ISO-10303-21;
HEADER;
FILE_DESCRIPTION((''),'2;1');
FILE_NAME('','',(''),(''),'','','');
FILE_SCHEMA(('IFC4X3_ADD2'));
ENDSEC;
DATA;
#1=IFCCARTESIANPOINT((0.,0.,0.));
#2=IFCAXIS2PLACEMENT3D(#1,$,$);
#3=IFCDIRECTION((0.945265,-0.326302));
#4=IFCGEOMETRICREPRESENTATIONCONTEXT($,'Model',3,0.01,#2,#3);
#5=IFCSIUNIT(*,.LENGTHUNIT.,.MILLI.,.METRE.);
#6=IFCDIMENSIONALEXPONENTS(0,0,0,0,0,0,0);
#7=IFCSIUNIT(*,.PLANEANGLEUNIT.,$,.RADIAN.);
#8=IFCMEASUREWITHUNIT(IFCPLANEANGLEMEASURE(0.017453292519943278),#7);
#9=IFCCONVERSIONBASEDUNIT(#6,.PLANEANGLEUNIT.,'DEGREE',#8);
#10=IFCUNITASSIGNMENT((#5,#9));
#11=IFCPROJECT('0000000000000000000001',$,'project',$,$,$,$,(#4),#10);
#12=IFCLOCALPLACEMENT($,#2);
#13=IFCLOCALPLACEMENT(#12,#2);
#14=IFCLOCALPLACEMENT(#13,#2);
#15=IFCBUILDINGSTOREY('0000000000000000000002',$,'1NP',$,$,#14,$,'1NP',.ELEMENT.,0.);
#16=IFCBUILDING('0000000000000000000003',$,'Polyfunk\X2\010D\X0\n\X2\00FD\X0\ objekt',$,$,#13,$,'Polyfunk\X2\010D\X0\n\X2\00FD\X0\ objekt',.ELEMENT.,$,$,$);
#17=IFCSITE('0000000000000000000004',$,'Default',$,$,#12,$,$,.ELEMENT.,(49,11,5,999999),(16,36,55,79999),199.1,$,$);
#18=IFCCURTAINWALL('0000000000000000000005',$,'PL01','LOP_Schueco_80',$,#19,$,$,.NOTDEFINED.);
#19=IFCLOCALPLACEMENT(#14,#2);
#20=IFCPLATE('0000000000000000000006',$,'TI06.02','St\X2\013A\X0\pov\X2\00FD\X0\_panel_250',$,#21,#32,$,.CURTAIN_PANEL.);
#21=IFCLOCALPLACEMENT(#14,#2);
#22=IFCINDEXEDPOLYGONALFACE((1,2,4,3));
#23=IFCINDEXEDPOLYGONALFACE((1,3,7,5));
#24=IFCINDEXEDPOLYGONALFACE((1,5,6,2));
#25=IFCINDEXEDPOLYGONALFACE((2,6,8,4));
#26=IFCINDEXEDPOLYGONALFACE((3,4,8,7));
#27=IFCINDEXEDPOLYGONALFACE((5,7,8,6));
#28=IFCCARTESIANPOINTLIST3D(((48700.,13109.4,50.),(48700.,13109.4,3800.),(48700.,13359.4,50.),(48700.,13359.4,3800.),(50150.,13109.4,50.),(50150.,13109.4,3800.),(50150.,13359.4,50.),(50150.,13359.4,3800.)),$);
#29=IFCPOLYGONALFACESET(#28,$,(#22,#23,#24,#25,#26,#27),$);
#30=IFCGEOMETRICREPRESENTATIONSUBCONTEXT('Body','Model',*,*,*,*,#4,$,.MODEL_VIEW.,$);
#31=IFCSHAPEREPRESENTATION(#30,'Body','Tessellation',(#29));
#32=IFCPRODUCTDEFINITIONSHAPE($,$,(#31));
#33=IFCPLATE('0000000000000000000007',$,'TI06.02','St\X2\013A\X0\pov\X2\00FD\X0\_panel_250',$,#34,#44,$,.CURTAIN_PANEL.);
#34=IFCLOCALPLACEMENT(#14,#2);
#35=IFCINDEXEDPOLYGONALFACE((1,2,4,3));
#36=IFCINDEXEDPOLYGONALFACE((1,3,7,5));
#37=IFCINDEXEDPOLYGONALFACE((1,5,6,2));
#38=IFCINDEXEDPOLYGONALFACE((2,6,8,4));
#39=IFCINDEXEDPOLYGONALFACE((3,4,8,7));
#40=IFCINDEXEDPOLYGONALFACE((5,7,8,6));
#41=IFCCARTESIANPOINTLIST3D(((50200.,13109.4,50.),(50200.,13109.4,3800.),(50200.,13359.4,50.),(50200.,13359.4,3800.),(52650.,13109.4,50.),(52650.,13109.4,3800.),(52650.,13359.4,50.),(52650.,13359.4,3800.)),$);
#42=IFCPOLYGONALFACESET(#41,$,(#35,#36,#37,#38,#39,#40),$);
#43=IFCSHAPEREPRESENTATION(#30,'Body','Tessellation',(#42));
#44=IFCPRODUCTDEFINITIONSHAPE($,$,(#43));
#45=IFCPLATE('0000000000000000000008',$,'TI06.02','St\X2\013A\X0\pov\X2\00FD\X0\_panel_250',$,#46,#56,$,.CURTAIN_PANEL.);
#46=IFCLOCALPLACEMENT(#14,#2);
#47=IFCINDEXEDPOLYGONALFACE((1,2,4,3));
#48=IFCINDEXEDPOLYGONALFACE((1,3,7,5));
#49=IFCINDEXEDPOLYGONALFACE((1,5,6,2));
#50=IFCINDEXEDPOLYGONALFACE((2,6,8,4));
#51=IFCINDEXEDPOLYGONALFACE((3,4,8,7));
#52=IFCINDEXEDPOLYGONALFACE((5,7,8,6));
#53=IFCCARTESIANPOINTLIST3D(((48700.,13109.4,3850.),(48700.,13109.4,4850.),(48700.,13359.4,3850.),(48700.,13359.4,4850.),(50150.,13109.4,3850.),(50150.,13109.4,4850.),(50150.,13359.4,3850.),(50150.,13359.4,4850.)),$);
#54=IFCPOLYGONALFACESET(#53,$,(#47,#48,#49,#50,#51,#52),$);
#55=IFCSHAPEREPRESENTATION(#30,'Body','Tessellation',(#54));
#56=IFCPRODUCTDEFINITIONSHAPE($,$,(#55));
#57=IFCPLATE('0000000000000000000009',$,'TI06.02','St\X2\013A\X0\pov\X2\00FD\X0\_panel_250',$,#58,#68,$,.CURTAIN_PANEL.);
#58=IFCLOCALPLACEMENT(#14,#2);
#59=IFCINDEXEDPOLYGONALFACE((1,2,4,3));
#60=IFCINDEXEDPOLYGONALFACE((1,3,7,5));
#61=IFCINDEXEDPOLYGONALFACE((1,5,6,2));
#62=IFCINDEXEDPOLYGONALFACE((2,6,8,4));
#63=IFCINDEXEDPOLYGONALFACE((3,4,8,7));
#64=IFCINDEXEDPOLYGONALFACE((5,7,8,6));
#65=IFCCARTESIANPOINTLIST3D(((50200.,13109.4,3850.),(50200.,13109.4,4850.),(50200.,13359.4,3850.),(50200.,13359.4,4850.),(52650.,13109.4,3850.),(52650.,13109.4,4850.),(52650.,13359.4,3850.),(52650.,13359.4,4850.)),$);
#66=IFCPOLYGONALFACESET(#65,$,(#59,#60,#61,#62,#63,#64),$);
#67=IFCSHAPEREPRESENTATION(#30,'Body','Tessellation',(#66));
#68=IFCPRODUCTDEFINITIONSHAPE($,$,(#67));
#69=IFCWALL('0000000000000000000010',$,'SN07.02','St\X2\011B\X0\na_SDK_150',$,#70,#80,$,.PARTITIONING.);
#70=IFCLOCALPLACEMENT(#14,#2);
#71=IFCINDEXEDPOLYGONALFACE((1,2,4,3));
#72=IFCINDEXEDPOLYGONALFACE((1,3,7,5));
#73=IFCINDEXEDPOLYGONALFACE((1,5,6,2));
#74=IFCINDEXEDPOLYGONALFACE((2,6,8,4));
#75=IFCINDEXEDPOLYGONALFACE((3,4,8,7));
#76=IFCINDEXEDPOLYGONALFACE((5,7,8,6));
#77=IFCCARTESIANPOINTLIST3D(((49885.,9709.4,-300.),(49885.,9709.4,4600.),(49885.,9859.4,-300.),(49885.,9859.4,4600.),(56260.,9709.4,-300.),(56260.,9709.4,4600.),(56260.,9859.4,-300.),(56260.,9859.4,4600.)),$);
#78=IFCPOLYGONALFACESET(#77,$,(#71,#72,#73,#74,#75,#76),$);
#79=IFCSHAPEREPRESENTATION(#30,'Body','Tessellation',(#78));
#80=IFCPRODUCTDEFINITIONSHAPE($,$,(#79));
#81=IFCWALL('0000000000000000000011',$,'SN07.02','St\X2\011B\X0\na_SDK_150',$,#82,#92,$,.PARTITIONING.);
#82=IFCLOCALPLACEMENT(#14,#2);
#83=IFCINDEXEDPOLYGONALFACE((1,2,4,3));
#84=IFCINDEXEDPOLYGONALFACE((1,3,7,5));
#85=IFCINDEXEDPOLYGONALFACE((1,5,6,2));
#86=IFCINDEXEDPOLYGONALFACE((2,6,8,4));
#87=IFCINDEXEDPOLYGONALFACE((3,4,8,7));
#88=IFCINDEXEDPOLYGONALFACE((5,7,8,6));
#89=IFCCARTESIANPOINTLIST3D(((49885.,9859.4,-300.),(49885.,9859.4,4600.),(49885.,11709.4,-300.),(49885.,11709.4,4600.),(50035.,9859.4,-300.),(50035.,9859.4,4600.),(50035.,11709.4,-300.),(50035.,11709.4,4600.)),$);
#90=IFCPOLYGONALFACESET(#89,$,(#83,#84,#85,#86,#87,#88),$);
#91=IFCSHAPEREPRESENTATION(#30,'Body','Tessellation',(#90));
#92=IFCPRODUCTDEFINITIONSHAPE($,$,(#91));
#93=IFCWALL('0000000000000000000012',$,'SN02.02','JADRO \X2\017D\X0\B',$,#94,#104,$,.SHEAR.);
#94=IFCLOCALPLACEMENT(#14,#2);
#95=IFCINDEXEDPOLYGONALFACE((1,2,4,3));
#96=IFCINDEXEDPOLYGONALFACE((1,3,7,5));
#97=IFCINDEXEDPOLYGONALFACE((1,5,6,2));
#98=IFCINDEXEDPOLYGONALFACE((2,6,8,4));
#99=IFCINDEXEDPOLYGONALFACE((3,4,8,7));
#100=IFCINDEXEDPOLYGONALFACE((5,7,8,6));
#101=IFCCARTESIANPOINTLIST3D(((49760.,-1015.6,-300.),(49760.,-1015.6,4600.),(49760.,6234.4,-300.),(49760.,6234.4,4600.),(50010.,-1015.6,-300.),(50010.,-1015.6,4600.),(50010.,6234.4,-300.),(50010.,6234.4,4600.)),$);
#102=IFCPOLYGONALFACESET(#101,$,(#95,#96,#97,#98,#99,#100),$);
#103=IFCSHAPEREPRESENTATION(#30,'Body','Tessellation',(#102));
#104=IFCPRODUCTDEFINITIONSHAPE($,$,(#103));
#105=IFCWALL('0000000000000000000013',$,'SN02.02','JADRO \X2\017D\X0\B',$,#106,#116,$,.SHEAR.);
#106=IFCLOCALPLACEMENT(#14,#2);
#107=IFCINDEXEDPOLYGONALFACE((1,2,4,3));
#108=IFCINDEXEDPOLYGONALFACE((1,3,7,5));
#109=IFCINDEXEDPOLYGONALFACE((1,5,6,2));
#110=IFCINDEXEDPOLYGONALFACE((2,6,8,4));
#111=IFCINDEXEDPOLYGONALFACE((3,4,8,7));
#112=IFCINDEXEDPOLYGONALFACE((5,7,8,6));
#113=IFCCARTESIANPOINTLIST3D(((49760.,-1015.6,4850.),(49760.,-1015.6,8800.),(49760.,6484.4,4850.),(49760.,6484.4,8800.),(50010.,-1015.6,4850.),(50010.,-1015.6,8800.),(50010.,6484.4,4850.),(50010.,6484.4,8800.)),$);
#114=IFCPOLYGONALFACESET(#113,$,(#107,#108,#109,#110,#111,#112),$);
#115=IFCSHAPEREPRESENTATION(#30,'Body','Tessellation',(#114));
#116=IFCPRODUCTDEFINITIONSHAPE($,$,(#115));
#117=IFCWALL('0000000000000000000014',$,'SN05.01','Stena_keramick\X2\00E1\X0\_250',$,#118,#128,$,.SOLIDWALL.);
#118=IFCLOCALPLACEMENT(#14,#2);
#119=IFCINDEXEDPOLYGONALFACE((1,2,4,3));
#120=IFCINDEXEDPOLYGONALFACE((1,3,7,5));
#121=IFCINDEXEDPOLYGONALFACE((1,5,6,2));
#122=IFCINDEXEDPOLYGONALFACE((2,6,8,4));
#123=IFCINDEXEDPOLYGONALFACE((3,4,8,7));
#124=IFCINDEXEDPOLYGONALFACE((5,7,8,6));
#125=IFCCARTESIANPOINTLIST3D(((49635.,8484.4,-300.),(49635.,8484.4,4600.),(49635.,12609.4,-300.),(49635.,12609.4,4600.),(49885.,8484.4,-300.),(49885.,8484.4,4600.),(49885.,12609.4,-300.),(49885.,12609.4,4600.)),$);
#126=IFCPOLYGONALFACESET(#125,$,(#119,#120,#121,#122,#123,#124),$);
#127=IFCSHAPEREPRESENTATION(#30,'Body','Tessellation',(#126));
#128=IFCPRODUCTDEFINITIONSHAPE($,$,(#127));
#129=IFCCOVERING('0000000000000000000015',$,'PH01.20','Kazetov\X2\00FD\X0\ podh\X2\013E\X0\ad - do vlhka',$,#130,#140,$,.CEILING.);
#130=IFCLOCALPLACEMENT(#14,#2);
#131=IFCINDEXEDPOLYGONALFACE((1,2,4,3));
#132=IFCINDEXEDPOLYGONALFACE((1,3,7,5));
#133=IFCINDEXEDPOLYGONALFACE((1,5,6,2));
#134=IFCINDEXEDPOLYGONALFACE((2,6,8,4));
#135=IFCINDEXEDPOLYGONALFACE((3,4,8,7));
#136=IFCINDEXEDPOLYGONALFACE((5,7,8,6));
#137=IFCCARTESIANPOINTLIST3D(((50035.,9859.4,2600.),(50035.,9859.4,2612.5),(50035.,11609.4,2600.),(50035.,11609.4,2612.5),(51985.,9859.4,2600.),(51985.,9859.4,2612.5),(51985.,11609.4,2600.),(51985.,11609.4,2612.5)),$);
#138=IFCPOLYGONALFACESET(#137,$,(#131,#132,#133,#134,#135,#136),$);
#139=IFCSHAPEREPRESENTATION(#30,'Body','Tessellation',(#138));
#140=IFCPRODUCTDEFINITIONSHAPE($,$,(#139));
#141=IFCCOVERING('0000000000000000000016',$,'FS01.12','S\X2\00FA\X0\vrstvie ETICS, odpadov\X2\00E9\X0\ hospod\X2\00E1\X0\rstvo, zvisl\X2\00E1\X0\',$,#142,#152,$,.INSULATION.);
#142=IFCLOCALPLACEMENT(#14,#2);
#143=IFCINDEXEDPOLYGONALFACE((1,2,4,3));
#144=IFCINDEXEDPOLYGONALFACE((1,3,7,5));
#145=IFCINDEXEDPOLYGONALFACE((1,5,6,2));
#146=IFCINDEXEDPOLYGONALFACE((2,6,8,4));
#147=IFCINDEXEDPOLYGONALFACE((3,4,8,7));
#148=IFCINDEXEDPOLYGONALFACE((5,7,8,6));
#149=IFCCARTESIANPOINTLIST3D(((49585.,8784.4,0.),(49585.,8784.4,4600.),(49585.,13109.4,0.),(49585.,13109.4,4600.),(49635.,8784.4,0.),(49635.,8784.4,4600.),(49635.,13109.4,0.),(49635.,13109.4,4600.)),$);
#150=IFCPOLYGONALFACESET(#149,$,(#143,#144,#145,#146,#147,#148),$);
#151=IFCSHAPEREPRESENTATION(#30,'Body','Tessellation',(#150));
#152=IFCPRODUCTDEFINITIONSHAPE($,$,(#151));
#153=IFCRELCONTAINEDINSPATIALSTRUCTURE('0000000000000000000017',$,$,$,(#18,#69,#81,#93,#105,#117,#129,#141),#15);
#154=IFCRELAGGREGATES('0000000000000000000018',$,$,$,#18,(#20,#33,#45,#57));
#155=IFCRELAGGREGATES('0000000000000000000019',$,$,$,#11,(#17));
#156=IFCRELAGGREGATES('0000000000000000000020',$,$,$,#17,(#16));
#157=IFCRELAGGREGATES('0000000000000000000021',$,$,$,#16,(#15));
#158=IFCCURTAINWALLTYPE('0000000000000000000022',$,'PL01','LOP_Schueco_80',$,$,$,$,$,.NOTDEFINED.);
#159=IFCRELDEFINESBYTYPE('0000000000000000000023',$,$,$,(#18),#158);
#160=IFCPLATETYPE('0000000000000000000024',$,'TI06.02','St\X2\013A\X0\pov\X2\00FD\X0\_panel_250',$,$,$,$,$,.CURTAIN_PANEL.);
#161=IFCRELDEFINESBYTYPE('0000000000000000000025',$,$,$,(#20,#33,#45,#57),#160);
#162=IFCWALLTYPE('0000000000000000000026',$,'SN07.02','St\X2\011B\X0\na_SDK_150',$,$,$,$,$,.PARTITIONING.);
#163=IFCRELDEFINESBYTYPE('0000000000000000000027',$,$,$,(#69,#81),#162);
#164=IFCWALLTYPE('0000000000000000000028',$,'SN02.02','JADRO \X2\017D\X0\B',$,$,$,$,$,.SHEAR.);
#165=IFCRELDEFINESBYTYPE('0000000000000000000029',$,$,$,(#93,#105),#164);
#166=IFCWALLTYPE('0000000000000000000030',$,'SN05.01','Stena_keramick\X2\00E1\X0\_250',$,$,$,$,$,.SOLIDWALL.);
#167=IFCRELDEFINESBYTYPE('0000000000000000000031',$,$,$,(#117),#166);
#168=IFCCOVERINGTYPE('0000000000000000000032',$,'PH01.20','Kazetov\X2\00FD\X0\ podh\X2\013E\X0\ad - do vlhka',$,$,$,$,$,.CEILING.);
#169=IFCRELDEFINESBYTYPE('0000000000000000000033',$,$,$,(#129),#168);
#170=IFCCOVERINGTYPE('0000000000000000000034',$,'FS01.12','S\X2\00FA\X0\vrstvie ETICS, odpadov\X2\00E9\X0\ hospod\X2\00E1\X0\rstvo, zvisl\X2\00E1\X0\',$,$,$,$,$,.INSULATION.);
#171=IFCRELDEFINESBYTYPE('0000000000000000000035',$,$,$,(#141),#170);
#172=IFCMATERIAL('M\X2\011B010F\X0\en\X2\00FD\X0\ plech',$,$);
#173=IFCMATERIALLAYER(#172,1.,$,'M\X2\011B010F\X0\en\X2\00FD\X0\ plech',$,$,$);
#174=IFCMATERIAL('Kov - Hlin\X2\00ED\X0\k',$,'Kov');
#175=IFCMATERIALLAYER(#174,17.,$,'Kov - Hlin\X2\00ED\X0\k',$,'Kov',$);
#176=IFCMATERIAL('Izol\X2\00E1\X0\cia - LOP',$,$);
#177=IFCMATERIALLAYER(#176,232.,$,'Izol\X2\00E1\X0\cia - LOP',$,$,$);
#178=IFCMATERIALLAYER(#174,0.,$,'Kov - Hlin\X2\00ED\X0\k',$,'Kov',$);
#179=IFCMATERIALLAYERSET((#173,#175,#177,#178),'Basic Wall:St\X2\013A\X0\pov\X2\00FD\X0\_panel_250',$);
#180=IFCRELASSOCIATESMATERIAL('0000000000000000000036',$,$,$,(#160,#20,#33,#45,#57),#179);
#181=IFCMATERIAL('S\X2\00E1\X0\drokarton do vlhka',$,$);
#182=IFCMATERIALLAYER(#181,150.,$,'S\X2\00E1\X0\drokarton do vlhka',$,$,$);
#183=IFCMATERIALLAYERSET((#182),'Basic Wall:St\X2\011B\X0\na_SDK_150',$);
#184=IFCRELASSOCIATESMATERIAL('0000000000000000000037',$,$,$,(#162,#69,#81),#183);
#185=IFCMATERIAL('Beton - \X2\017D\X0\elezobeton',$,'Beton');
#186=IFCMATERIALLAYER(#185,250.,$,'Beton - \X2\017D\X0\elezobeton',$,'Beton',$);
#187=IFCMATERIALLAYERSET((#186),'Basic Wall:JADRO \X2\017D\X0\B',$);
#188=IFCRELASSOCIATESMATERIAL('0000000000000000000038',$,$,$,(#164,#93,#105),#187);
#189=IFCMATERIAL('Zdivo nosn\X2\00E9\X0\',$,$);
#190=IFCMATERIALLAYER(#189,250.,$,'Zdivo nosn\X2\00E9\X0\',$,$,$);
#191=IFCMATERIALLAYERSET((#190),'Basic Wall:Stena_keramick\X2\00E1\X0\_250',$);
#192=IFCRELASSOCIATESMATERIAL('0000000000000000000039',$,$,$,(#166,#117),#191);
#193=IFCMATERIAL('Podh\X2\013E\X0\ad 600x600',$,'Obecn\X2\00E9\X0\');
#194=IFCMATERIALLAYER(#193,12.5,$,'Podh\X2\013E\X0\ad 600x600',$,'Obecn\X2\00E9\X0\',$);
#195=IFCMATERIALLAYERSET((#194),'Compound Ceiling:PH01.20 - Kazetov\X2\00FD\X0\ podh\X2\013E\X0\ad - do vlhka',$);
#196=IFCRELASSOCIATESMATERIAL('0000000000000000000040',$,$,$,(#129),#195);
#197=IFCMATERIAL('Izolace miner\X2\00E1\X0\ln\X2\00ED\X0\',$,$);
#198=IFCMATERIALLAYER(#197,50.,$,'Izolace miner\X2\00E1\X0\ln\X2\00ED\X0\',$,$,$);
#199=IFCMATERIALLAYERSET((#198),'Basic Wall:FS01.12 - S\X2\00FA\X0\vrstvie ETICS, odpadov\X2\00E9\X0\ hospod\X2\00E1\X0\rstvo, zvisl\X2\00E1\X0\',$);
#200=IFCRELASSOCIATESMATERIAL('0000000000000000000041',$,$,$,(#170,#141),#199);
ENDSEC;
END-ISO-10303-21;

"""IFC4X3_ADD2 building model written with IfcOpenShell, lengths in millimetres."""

from ifc_helpers import new_model, entity, si_unit, converted_unit, direction, frame, frame_2d, origin, origin_2d_with_axis, place, context, subcontext, project, spatial, polyline, rectangle, extrude, clip, bounded_halfspace, material, layer, layer_set, layer_usage, type_object, element, aggregate, save


model = new_model("IFC4X3_ADD2")

# Units and contexts
model_context = context("Model", 3, precision=0.01, world=origin(), true_north=direction((0.945265, -0.326302)))
body_context = subcontext(model_context, "Body", "Model", "MODEL_VIEW")
ifc_project = project(units=[si_unit("LENGTHUNIT", "METRE", prefix="MILLI"), converted_unit("PLANEANGLEUNIT", "DEGREE", entity("IfcPlaneAngleMeasure", 0.017453292519943278), si_unit("PLANEANGLEUNIT", "RADIAN"), dimensions=[0, 0, 0, 0, 0, 0, 0])], contexts=[model_context])

# Site, building, storey
site_placement = place(None, origin())
site = spatial("IfcSite", under=ifc_project, at=site_placement, Name="Default", CompositionType="ELEMENT", RefLatitude=(49, 11, 5, 999999), RefLongitude=(16, 36, 55, 79999), RefElevation=199.1)
building_placement = place(site_placement, origin())
building = spatial("IfcBuilding", under=site, at=building_placement, Name="Polyfunkčný objekt", LongName="Polyfunkčný objekt", CompositionType="ELEMENT")
storey_placement = place(building_placement, origin())
storey = spatial("IfcBuildingStorey", under=building, at=storey_placement, Name="1NP", LongName="1NP", CompositionType="ELEMENT", Elevation=0.0)

# Curtain wall, plates
curtain_wall_type = type_object("IfcCurtainWallType", Name="PL01", Description="LOP_Schueco_80", PredefinedType="NOTDEFINED")
curtain_wall_placement = place(storey_placement, origin())
curtain_wall = element("IfcCurtainWall", 1, at=curtain_wall_placement, inside=storey, type_object=curtain_wall_type, Name="PL01", Description="LOP_Schueco_80", PredefinedType="NOTDEFINED")
ifc_material_1 = material(Name="Měďený plech")
ifc_layer_1 = layer(ifc_material_1, 1.0, Name="Měďený plech")
ifc_material_2 = material(Name="Kov - Hliník", Category="Kov")
ifc_layer_2 = layer(ifc_material_2, 17.0, Name="Kov - Hliník", Category="Kov")
ifc_material_3 = material(Name="Izolácia - LOP")
ifc_layer_3 = layer(ifc_material_3, 232.0, Name="Izolácia - LOP")
ifc_layer_4 = layer(ifc_material_2, 0.0, Name="Kov - Hliník", Category="Kov")
ifc_layer_set_1 = layer_set([ifc_layer_1, ifc_layer_2, ifc_layer_3, ifc_layer_4], Name="Basic Wall:Stĺpový_panel_250")
ifc_layer_usage_1 = layer_usage(ifc_layer_set_1, "AXIS2", "NEGATIVE", 125.0)
plate_type = type_object("IfcPlateType", Name="TI06.02", Description="Stĺpový_panel_250", PredefinedType="CURTAIN_PANEL", material=ifc_layer_set_1)
plate_1_placement = place(storey_placement, frame((48700.0, 13234.4, 50.0)))
plate_1 = element("IfcPlate", 2, at=plate_1_placement, type_object=plate_type, material=ifc_layer_usage_1, Name="TI06.02", Description="Stĺpový_panel_250", PredefinedType="CURTAIN_PANEL", context=body_context, shape_type="SweptSolid", body=[
    extrude(rectangle(XDim=250.0, YDim=1450.0, at=frame_2d((0.0, 0.0), x_axis=(1.0, 0.0))), frame((725.0, 0.0, 0.0), z_axis=(0.0, 0.0, 1.0), x_axis=(0.0, 1.0, 0.0)), (0.0, 0.0, 1.0), 3750.0),
])
ifc_layer_usage_2 = layer_usage(ifc_layer_set_1, "AXIS2", "NEGATIVE", 125.0)
plate_2_placement = place(storey_placement, frame((50200.0, 13234.4, 50.0)))
plate_2 = element("IfcPlate", 3, at=plate_2_placement, type_object=plate_type, material=ifc_layer_usage_2, Name="TI06.02", Description="Stĺpový_panel_250", PredefinedType="CURTAIN_PANEL", context=body_context, shape_type="SweptSolid", body=[
    extrude(rectangle(XDim=250.0, YDim=2450.0, at=origin_2d_with_axis()), frame((1225.0, 0.0, 0.0), z_axis=(0.0, 0.0, 1.0), x_axis=(0.0, 1.0, 0.0)), (0.0, 0.0, 1.0), 3750.0),
])
ifc_layer_usage_3 = layer_usage(ifc_layer_set_1, "AXIS2", "NEGATIVE", 125.0)
plate_3_placement = place(storey_placement, frame((48700.0, 13234.4, 3850.0)))
plate_3 = element("IfcPlate", 4, at=plate_3_placement, type_object=plate_type, material=ifc_layer_usage_3, Name="TI06.02", Description="Stĺpový_panel_250", PredefinedType="CURTAIN_PANEL", context=body_context, shape_type="SweptSolid", body=[
    extrude(rectangle(XDim=250.0, YDim=1450.0, at=frame_2d((0.0, 0.0), x_axis=(1.0, 0.0))), frame((725.0, 0.0, 0.0), z_axis=(0.0, 0.0, 1.0), x_axis=(0.0, 1.0, 0.0)), (0.0, 0.0, 1.0), 1000.0),
])
ifc_layer_usage_4 = layer_usage(ifc_layer_set_1, "AXIS2", "NEGATIVE", 125.0)
plate_4_placement = place(storey_placement, frame((50200.0, 13234.4, 3850.0)))
plate_4 = element("IfcPlate", 5, at=plate_4_placement, type_object=plate_type, material=ifc_layer_usage_4, Name="TI06.02", Description="Stĺpový_panel_250", PredefinedType="CURTAIN_PANEL", context=body_context, shape_type="SweptSolid", body=[
    extrude(rectangle(XDim=250.0, YDim=2450.0, at=origin_2d_with_axis()), frame((1225.0, 0.0, 0.0), z_axis=(0.0, 0.0, 1.0), x_axis=(0.0, 1.0, 0.0)), (0.0, 0.0, 1.0), 1000.0),
])
aggregate(curtain_wall, [plate_1, plate_2, plate_3, plate_4])

# Walls
ifc_material_4 = material(Name="Sádrokarton do vlhka")
ifc_layer_5 = layer(ifc_material_4, 150.0, Name="Sádrokarton do vlhka")
ifc_layer_set_2 = layer_set([ifc_layer_5], Name="Basic Wall:Stěna_SDK_150")
wall_type_1 = type_object("IfcWallType", Name="SN07.02", Description="Stěna_SDK_150", PredefinedType="PARTITIONING", material=ifc_layer_set_2)
wall_1_placement = place(storey_placement, frame((49885.0, 9784.4, -300.0)))
element("IfcWall", 6, at=wall_1_placement, inside=storey, type_object=wall_type_1, material=ifc_layer_set_2, Name="SN07.02", Description="Stěna_SDK_150", PredefinedType="PARTITIONING", context=body_context, shape_type="Clipping", body=[
    clip(clip(extrude(rectangle(XDim=6375.0, YDim=150.0, at=frame_2d((3187.5, 0.0), x_axis=(-1.0, 0.0))), origin(), (0.0, 0.0, 1.0), 4900.0), bounded_halfspace(frame((0.0, -75.0, 4900.0), z_axis=(0.0, 0.0, -1.0), x_axis=(1.0, 0.0, 0.0)), True, frame((0.0, -75.0, 4900.0)), polyline([(0.0, 0.0), (6375.0, 0.0), (6375.0, 150.0), (2250.0, 150.0), (2100.0, 150.0), (1200.0, 150.0), (1050.0, 150.0), (150.0, 150.0), (0.0, 150.0), (0.0, 0.0)]))), bounded_halfspace(frame((6375.0, -75.0, 0.0), z_axis=(0.0, 0.0, 1.0), x_axis=(0.0, 1.0, 0.0)), True, frame((6375.0, -75.0, 0.0)), polyline([(0.0, 0.0), (0.0, 150.0), (-4125.0, 150.0), (-4275.0, 150.0), (-5175.0, 150.0), (-5325.0, 150.0), (-6225.0, 150.0), (-6375.0, 150.0), (-6375.0, 0.0), (0.0, 0.0)]))),
])
wall_2_placement = place(storey_placement, frame((49960.0, 9859.4, -300.0), z_axis=(0.0, 0.0, 1.0), x_axis=(0.0, 1.0, 0.0)))
element("IfcWall", 7, at=wall_2_placement, inside=storey, type_object=wall_type_1, material=ifc_layer_set_2, Name="SN07.02", Description="Stěna_SDK_150", PredefinedType="PARTITIONING", context=body_context, shape_type="Clipping", body=[
    clip(clip(extrude(rectangle(XDim=1850.0, YDim=150.0, at=frame_2d((925.0, 0.0), x_axis=(-1.0, 0.0))), origin(), (0.0, 0.0, 1.0), 4900.0), bounded_halfspace(frame((0.0, -75.0, 4900.0), z_axis=(0.0, 0.0, -1.0), x_axis=(0.0, -1.0, 0.0)), True, frame((0.0, -75.0, 4900.0)), polyline([(0.0, 0.0), (1750.0, 0.0), (1850.0, 0.0), (1850.0, 150.0), (0.0, 150.0), (0.0, 0.0)]))), bounded_halfspace(frame((1850.0, -75.0, 0.0)), True, frame((1850.0, -75.0, 0.0)), polyline([(0.0, 0.0), (0.0, 150.0), (-1850.0, 150.0), (-1850.0, 0.0), (-100.0, 0.0), (0.0, 0.0)]))),
])
ifc_material_5 = material(Name="Beton - Železobeton", Category="Beton")
ifc_layer_6 = layer(ifc_material_5, 250.0, Name="Beton - Železobeton", Category="Beton")
ifc_layer_set_3 = layer_set([ifc_layer_6], Name="Basic Wall:JADRO ŽB")
wall_type_2 = type_object("IfcWallType", Name="SN02.02", Description="JADRO ŽB", PredefinedType="SHEAR", material=ifc_layer_set_3)
wall_3_placement = place(storey_placement, frame((49885.0, 6234.4, -300.0), z_axis=(0.0, 0.0, 1.0), x_axis=(0.0, -1.0, 0.0)))
element("IfcWall", 8, at=wall_3_placement, inside=storey, type_object=wall_type_2, material=ifc_layer_set_3, Name="SN02.02", Description="JADRO ŽB", PredefinedType="SHEAR", context=body_context, shape_type="Clipping", body=[
    clip(clip(extrude(rectangle(XDim=7250.0, YDim=250.0, at=frame_2d((3625.0, 0.0), x_axis=(-1.0, 0.0))), origin(), (0.0, 0.0, 1.0), 4900.0), bounded_halfspace(frame((0.0, -125.0, 4900.0), z_axis=(0.0, 0.0, -1.0), x_axis=(0.0, 1.0, 0.0)), True, frame((0.0, -125.0, 4900.0)), polyline([(0.0, 0.0), (800.0, 0.0), (950.0, 0.0), (7250.0, 0.0), (7250.0, 250.0), (0.0, 250.0), (0.0, 0.0)]))), bounded_halfspace(frame((7250.0, -125.0, 0.0), z_axis=(0.0, 0.0, 1.0), x_axis=(-1.0, 0.0, 0.0)), True, frame((7250.0, -125.0, 0.0)), polyline([(0.0, 0.0), (0.0, 250.0), (-7250.0, 250.0), (-7250.0, 0.0), (-6450.0, 0.0), (-6300.0, 0.0), (0.0, 0.0)]))),
])
wall_4_placement = place(storey_placement, frame((49885.0, 6484.4, 4850.0), z_axis=(0.0, 0.0, 1.0), x_axis=(0.0, -1.0, 0.0)))
element("IfcWall", 9, at=wall_4_placement, inside=storey, type_object=wall_type_2, material=ifc_layer_set_3, Name="SN02.02", Description="JADRO ŽB", PredefinedType="SHEAR", context=body_context, shape_type="Clipping", body=[
    clip(clip(extrude(rectangle(XDim=7500.0, YDim=250.0, at=frame_2d((3750.0, 0.0), x_axis=(-1.0, 0.0))), origin(), (0.0, 0.0, 1.0), 3950.0), bounded_halfspace(frame((7500.0, -125.0, 0.0), z_axis=(0.0, 0.0, 1.0), x_axis=(0.0, -1.0, 0.0)), True, frame((7500.0, -125.0, 0.0)), polyline([(0.0, 0.0), (0.0, 250.0), (-7500.0, 250.0), (-7500.0, 0.0), (-7250.0, 0.0), (-6450.0, 0.0), (-6300.0, 0.0), (0.0, 0.0)]))), bounded_halfspace(frame((0.0, -125.0, 3950.0), z_axis=(0.0, 0.0, -1.0), x_axis=(0.0, 1.0, 0.0)), True, frame((0.0, -125.0, 3950.0)), polyline([(0.0, 0.0), (250.0, 0.0), (1050.0, 0.0), (1200.0, 0.0), (7500.0, 0.0), (7500.0, 250.0), (0.0, 250.0), (0.0, 0.0)]))),
])
ifc_material_6 = material(Name="Zdivo nosné")
ifc_layer_7 = layer(ifc_material_6, 250.0, Name="Zdivo nosné")
ifc_layer_set_4 = layer_set([ifc_layer_7], Name="Basic Wall:Stena_keramická_250")
wall_type_3 = type_object("IfcWallType", Name="SN05.01", Description="Stena_keramická_250", PredefinedType="SOLIDWALL", material=ifc_layer_set_4)
wall_5_placement = place(storey_placement, frame((49760.0, 12609.4, -300.0), z_axis=(0.0, 0.0, 1.0), x_axis=(0.0, -1.0, 0.0)))
element("IfcWall", 10, at=wall_5_placement, inside=storey, type_object=wall_type_3, material=ifc_layer_set_4, Name="SN05.01", Description="Stena_keramická_250", PredefinedType="SOLIDWALL", context=body_context, shape_type="Clipping", body=[
    clip(clip(extrude(rectangle(XDim=4125.0, YDim=250.0, at=frame_2d((2062.5, 0.0), x_axis=(-1.0, 0.0))), origin(), (0.0, 0.0, 1.0), 4900.0), bounded_halfspace(frame((0.0, -125.0, 4900.0), z_axis=(0.0, 0.0, -1.0), x_axis=(0.0, 1.0, 0.0)), True, frame((0.0, -125.0, 4900.0)), polyline([(0.0, 0.0), (3875.0, 0.0), (4125.0, 0.0), (4125.0, 250.0), (0.0, 250.0), (0.0, 0.0)]))), bounded_halfspace(frame((4125.0, -125.0, 0.0), z_axis=(0.0, 0.0, 1.0), x_axis=(-1.0, 0.0, 0.0)), True, frame((4125.0, -125.0, 0.0)), polyline([(0.0, 0.0), (0.0, 250.0), (-4125.0, 250.0), (-4125.0, 0.0), (-250.0, 0.0), (0.0, 0.0)]))),
])

# Coverings
ifc_material_7 = material(Name="Podhľad 600x600", Category="Obecné")
ifc_layer_8 = layer(ifc_material_7, 12.5, Name="Podhľad 600x600", Category="Obecné")
ifc_layer_set_5 = layer_set([ifc_layer_8], Name="Compound Ceiling:PH01.20 - Kazetový podhľad - do vlhka")
ifc_layer_usage_5 = layer_usage(ifc_layer_set_5, "AXIS3", "NEGATIVE", 0.0)
covering_type_1 = type_object("IfcCoveringType", Name="PH01.20", Description="Kazetový podhľad - do vlhka", PredefinedType="CEILING")
covering_1_placement = place(storey_placement, frame((50035.0, 9859.4, 2600.0)))
element("IfcCovering", 11, at=covering_1_placement, inside=storey, type_object=covering_type_1, material=ifc_layer_usage_5, Name="PH01.20", Description="Kazetový podhľad - do vlhka", PredefinedType="CEILING", context=body_context, shape_type="SweptSolid", body=[
    extrude(rectangle(XDim=1950.0, YDim=1750.0, at=origin_2d_with_axis()), frame((975.0, 875.0, 0.0), z_axis=(0.0, 0.0, 1.0), x_axis=(-1.0, 0.0, 0.0)), (0.0, 0.0, 1.0), 12.5),
])
ifc_material_8 = material(Name="Izolace minerální")
ifc_layer_9 = layer(ifc_material_8, 50.0, Name="Izolace minerální")
ifc_layer_set_6 = layer_set([ifc_layer_9], Name="Basic Wall:FS01.12 - Súvrstvie ETICS, odpadové hospodárstvo, zvislá")
covering_type_2 = type_object("IfcCoveringType", Name="FS01.12", Description="Súvrstvie ETICS, odpadové hospodárstvo, zvislá", PredefinedType="INSULATION", material=ifc_layer_set_6)
covering_2_placement = place(storey_placement, frame((49610.0, 8784.4, 0.0), z_axis=(0.0, 0.0, 1.0), x_axis=(0.0, 1.0, 0.0)))
element("IfcCovering", 12, at=covering_2_placement, inside=storey, type_object=covering_type_2, material=ifc_layer_set_6, Name="FS01.12", Description="Súvrstvie ETICS, odpadové hospodárstvo, zvislá", PredefinedType="INSULATION", context=body_context, shape_type="SweptSolid", body=[
    extrude(rectangle(XDim=4325.0, YDim=50.0, at=frame_2d((2162.5, 0.0), x_axis=(-1.0, 0.0))), origin(), (0.0, 0.0, 1.0), 4600.0),
])

save(model, "model.ifc")
